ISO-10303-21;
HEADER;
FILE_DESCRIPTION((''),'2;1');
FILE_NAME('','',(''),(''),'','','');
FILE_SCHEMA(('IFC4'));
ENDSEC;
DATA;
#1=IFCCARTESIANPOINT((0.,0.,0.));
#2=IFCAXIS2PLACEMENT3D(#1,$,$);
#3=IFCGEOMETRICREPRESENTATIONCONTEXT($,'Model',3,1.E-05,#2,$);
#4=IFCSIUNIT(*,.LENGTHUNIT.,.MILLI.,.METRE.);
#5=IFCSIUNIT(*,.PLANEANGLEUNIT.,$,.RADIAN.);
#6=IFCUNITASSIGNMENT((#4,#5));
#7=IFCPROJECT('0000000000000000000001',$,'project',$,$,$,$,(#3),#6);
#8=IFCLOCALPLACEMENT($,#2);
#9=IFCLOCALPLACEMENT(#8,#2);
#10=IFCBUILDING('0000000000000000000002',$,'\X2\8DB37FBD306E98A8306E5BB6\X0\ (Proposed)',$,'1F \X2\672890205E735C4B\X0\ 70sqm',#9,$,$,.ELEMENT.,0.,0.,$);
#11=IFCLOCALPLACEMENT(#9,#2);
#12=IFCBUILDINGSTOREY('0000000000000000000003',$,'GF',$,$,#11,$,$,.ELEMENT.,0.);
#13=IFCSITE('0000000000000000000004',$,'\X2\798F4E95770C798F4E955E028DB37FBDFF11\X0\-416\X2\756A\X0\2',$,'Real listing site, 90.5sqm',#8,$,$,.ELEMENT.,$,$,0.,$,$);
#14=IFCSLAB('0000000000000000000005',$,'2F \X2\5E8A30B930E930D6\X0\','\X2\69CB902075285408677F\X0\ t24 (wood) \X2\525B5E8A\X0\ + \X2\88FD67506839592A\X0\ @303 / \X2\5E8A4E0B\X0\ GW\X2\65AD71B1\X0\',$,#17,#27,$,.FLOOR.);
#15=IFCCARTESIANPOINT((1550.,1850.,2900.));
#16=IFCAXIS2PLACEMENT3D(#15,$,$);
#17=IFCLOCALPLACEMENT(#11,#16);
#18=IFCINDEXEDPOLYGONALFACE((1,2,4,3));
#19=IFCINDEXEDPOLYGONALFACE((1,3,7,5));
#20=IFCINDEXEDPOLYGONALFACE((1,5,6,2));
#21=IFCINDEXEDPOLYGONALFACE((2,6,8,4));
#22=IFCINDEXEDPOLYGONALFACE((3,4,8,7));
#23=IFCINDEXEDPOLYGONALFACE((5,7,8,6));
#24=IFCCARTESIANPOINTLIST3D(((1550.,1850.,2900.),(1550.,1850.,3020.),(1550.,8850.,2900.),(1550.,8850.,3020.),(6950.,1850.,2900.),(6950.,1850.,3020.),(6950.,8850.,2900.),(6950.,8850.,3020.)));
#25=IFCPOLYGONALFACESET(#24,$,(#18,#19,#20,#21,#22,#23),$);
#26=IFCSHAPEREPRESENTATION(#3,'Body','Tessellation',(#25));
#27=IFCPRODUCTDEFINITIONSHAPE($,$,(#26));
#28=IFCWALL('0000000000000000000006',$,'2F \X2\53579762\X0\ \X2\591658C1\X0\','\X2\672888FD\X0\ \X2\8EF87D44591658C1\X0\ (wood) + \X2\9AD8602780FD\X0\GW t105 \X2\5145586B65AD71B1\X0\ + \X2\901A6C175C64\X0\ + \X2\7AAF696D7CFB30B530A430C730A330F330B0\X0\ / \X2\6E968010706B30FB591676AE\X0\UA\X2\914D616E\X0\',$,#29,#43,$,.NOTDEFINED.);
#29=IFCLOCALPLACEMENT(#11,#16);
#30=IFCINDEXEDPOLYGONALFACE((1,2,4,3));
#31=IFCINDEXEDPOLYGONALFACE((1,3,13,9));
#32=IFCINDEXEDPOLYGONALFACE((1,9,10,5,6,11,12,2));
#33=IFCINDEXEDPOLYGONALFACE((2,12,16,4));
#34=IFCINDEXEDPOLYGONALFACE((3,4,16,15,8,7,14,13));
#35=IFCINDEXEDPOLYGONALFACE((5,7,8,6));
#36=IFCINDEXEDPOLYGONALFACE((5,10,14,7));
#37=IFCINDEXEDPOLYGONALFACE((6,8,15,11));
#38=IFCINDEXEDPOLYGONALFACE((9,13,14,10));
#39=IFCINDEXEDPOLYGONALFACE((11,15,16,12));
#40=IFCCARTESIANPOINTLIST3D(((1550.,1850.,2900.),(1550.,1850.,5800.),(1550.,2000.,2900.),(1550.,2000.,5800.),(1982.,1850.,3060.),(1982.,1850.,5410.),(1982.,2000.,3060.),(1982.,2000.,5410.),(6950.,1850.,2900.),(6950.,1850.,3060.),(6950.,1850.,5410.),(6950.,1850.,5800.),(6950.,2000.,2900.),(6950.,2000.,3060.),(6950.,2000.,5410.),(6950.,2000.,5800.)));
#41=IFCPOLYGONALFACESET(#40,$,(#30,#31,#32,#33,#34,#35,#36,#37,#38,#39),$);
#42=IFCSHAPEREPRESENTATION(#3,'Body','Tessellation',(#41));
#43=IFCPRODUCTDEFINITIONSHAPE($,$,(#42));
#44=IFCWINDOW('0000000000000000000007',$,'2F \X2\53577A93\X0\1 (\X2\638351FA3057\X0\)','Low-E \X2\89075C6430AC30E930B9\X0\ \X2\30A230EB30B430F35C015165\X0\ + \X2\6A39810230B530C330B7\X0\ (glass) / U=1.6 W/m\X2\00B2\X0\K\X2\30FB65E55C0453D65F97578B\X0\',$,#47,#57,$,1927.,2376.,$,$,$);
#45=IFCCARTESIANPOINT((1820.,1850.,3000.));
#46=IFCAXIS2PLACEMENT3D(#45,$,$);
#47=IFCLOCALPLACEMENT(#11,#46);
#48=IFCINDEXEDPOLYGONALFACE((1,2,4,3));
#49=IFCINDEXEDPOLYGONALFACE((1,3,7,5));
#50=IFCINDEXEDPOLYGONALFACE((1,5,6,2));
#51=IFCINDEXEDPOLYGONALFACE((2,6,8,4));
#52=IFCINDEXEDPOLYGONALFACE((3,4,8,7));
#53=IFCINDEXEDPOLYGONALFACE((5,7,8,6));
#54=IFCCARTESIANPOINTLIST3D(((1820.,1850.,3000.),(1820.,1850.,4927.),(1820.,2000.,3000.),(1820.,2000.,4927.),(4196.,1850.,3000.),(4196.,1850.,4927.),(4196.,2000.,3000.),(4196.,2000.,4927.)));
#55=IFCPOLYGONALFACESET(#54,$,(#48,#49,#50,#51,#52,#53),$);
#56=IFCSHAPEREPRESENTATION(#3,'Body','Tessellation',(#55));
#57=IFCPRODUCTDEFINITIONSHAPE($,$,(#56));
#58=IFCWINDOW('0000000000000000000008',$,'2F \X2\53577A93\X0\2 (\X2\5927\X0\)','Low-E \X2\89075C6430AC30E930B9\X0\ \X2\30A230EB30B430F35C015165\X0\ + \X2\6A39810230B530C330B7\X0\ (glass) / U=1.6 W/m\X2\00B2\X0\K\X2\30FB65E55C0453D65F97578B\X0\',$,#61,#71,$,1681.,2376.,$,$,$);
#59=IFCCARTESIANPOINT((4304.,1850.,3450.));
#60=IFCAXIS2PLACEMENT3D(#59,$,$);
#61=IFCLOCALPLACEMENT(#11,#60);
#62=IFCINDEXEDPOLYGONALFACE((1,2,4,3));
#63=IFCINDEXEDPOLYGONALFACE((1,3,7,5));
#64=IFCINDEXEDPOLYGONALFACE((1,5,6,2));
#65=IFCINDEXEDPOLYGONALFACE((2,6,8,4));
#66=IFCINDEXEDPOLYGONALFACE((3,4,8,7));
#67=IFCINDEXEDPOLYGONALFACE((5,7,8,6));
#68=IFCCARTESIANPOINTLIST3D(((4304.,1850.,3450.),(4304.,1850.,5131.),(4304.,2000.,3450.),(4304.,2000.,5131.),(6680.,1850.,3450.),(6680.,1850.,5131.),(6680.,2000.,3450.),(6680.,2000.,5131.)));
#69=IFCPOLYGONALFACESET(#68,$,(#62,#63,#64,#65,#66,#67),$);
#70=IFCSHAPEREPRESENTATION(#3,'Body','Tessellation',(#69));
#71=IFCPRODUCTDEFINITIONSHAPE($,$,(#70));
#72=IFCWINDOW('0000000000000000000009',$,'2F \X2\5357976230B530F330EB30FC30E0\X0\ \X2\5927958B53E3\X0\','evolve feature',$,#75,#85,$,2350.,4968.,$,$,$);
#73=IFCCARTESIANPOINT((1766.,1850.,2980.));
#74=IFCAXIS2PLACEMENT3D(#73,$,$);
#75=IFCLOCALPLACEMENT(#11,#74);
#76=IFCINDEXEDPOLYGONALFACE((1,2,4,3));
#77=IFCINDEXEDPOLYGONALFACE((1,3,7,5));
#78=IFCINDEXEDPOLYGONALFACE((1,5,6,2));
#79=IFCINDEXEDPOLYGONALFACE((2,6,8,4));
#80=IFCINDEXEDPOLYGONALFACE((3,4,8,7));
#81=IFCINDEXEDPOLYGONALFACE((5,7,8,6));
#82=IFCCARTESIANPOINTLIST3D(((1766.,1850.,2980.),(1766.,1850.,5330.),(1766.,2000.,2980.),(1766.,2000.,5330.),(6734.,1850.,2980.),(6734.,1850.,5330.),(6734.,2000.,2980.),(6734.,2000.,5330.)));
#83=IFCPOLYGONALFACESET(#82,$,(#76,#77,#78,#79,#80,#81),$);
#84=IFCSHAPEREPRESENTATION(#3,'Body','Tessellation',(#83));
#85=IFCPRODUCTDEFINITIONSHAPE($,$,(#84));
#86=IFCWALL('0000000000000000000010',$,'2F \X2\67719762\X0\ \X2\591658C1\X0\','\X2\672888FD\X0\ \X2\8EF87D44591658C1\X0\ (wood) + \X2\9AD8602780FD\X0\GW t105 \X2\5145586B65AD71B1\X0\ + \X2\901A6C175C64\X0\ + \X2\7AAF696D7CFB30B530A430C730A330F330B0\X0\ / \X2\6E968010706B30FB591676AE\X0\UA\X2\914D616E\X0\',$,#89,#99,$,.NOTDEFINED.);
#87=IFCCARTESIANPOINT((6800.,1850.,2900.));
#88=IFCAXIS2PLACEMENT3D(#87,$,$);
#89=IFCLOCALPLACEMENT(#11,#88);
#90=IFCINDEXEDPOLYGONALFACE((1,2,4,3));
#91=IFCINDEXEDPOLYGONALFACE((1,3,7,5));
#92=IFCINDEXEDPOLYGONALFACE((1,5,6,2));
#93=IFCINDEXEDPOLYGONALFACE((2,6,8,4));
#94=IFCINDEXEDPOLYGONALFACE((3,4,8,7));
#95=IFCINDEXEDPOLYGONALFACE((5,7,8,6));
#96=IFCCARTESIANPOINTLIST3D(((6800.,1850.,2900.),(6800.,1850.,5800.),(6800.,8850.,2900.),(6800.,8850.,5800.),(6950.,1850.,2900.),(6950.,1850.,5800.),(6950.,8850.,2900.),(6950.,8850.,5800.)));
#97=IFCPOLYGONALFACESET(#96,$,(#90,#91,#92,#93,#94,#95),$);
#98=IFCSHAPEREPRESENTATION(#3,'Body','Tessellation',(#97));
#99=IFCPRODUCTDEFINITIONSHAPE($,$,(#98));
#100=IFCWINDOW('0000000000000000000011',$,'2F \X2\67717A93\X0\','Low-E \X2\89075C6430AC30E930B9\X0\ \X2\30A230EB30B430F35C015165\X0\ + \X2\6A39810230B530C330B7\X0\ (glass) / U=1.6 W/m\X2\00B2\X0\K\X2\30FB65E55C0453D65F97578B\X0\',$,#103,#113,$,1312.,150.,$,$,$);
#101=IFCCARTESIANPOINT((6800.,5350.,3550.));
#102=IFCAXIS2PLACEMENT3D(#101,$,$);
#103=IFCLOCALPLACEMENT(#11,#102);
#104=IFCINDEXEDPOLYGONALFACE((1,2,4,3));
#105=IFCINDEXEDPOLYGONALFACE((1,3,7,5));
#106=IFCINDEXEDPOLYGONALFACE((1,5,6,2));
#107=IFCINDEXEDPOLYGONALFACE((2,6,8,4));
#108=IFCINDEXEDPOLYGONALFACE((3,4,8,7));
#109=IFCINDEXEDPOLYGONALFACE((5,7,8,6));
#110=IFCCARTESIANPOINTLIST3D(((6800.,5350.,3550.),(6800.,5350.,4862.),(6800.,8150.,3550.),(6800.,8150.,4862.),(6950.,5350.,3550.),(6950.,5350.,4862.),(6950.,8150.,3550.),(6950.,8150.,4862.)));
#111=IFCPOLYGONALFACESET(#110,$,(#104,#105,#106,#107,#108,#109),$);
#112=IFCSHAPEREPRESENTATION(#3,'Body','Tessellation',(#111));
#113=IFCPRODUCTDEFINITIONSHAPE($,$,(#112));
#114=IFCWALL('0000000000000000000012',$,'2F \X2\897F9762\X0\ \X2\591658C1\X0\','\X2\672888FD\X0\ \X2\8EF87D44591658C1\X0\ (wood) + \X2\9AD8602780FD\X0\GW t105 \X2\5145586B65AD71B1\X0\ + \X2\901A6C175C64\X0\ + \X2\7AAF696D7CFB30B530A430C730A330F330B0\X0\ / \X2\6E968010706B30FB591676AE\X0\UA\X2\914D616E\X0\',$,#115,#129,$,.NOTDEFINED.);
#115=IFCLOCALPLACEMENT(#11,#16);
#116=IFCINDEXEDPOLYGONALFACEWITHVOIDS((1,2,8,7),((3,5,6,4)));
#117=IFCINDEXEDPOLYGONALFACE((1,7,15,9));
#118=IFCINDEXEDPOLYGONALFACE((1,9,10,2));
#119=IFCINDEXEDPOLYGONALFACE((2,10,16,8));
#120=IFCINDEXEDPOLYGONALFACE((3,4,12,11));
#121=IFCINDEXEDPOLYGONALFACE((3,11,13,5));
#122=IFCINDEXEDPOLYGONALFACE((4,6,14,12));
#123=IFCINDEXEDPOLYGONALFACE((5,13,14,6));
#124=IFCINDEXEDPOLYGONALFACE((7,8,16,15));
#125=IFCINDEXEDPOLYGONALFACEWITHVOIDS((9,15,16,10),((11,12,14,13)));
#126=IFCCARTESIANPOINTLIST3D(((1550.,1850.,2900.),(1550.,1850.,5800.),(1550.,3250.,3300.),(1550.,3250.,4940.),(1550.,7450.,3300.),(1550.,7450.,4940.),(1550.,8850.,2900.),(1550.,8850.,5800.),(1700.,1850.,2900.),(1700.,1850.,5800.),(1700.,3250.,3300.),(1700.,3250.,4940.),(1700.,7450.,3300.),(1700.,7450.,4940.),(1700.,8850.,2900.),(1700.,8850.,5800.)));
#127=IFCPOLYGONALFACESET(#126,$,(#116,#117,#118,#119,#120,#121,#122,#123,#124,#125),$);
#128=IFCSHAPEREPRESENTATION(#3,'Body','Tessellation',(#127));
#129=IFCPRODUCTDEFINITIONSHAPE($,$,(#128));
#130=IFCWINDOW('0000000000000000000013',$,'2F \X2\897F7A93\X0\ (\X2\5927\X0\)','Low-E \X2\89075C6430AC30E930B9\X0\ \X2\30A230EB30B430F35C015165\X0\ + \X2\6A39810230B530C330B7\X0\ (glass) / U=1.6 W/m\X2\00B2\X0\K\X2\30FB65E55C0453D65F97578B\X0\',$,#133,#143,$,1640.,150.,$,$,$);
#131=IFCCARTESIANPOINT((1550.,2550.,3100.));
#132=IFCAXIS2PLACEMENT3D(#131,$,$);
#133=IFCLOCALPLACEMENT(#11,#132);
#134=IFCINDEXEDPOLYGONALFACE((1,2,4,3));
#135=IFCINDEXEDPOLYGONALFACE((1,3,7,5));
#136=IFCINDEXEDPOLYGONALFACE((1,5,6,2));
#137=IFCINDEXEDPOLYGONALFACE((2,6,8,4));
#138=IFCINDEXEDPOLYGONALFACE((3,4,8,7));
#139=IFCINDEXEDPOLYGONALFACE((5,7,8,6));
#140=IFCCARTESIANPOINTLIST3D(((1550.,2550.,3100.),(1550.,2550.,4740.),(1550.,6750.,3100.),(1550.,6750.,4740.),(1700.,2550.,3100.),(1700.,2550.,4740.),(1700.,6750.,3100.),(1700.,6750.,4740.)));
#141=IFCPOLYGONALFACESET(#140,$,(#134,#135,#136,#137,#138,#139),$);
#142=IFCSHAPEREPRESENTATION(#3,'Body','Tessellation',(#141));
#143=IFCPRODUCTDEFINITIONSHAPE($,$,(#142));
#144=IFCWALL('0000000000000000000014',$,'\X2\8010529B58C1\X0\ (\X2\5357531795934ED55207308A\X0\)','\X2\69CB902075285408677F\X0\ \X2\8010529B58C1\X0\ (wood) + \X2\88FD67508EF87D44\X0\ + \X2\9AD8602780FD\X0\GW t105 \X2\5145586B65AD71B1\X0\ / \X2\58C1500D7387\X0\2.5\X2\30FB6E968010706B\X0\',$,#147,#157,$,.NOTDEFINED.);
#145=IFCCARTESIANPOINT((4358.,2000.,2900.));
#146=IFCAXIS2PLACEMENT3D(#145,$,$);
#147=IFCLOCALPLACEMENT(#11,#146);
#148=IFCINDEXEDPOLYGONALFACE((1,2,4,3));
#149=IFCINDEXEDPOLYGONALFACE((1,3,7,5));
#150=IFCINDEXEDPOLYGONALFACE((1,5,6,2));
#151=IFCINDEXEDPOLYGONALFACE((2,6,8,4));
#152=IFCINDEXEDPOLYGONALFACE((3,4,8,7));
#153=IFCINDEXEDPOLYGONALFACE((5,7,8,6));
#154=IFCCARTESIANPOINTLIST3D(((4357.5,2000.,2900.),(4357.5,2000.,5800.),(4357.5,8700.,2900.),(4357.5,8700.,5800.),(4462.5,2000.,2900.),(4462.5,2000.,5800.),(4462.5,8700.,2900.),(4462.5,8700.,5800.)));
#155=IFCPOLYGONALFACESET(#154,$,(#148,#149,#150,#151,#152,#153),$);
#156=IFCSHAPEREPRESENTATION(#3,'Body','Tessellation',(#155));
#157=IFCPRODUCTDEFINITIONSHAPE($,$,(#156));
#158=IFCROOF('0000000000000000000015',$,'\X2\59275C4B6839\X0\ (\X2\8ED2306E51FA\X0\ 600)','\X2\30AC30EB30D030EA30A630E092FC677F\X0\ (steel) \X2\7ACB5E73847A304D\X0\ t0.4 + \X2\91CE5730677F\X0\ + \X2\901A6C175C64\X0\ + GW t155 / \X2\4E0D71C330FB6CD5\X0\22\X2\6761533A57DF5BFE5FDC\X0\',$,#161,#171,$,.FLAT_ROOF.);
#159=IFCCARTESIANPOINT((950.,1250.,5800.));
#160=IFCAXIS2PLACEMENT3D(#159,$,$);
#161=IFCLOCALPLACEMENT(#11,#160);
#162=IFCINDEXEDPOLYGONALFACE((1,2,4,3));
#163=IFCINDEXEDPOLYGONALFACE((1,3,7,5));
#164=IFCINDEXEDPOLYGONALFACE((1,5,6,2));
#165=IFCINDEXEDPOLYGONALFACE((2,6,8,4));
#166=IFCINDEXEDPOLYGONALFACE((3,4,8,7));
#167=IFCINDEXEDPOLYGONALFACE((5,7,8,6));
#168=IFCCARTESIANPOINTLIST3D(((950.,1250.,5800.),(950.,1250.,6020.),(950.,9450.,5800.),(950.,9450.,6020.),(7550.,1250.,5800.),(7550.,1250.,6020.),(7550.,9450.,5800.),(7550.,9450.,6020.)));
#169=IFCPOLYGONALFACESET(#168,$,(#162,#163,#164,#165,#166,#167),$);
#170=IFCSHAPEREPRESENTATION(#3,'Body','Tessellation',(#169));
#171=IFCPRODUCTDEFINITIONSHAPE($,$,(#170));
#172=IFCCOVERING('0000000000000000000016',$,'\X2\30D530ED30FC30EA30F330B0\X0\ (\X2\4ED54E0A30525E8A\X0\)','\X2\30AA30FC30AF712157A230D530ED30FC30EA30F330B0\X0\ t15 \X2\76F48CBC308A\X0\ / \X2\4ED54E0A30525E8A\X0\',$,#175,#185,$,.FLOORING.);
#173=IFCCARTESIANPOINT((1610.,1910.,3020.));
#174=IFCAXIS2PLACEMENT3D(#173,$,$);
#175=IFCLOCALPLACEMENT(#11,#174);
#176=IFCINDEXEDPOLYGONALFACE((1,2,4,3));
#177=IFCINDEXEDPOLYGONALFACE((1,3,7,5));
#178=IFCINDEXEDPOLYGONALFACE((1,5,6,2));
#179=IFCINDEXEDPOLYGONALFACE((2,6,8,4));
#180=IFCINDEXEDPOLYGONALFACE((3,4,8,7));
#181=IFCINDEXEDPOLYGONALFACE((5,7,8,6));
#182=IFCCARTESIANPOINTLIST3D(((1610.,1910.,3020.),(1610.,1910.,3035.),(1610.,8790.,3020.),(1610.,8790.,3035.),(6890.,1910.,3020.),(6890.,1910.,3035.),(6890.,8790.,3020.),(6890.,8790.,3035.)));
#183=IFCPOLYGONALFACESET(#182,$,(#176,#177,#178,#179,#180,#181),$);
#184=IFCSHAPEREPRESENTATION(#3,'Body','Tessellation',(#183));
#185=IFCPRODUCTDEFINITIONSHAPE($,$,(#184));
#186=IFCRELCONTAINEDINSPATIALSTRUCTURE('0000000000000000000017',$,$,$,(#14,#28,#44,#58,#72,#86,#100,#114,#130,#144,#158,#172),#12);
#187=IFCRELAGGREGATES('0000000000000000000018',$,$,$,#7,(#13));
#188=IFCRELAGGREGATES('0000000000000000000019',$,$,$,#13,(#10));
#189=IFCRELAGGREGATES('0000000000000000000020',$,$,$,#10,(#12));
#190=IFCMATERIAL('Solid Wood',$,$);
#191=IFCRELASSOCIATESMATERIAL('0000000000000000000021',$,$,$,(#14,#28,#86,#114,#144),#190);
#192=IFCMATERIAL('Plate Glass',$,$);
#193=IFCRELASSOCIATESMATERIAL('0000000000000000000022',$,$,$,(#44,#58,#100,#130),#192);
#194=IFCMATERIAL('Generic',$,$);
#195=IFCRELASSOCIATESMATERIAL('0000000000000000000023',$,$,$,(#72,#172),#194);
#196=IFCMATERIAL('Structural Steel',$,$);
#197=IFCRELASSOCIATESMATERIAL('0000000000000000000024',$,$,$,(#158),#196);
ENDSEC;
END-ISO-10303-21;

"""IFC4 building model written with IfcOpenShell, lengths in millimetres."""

from ifc_helpers import new_model, si_unit, frame, frame_2d, origin, place, context, project, spatial, rectangle, extrude, material, element, fill, save


model = new_model("IFC4")

# Units and contexts
model_context = context("Model", 3, precision=1e-05, world=origin())
ifc_project = project(units=[si_unit("LENGTHUNIT", "METRE", prefix="MILLI"), si_unit("PLANEANGLEUNIT", "RADIAN")], contexts=[model_context])

# Site, building, storey
site_placement = place(None, origin())
site = spatial("IfcSite", under=ifc_project, at=site_placement, Name="福井県福井市足羽１-416番2", ObjectType="Real listing site, 90.5sqm", CompositionType="ELEMENT", RefElevation=0.0)
building_placement = place(site_placement, origin())
building = spatial("IfcBuilding", under=site, at=building_placement, Name="足羽の風の家 (Proposed)", ObjectType="1F 木造平屋 70sqm", CompositionType="ELEMENT", ElevationOfRefHeight=0.0, ElevationOfTerrain=0.0)
storey_placement = place(building_placement, origin())
storey = spatial("IfcBuildingStorey", under=building, at=storey_placement, Name="GF", CompositionType="ELEMENT", Elevation=0.0)

# Slab
ifc_material_1 = material(Name="Solid Wood")
slab_placement = place(storey_placement, frame((1550.0, 1850.0, 2900.0)))
element("IfcSlab", 1, at=slab_placement, inside=storey, material=ifc_material_1, Name="2F 床スラブ", Description="構造用合板 t24 (wood) 剛床 + 製材根太 @303 / 床下 GW断熱", PredefinedType="FLOOR", context=model_context, shape_type="SweptSolid", body=[
    extrude(rectangle(XDim=5400.0, YDim=7000.0, at=frame_2d((2700.0, 3500.0))), frame((1550.0, 1850.0, 2900.0)), (0.0, 0.0, 1.0), 120.0),
])

# Wall, openings, windows
wall_1_placement = place(storey_placement, frame((1550.0, 1850.0, 2900.0)))
wall_1 = element("IfcWall", 2, at=wall_1_placement, inside=storey, material=ifc_material_1, Name="2F 南面 外壁", Description="木製 軸組外壁 (wood) + 高性能GW t105 充填断熱 + 通気層 + 窯業系サイディング / 準耐火・外皮UA配慮", PredefinedType="NOTDEFINED", context=model_context, shape_type="SweptSolid", body=[
    extrude(rectangle(XDim=5400.0, YDim=150.0, at=frame_2d((2700.0, 75.0))), frame((1550.0, 1850.0, 2900.0)), (0.0, 0.0, 1.0), 2900.0),
])
opening_1_placement = place(storey_placement, frame((1820.0, 1850.0, 3000.0)))
opening_1 = element("IfcOpeningElement", 3, at=opening_1_placement, cuts=wall_1, PredefinedType="NOTDEFINED", context=model_context, shape_type="SweptSolid", body=[
    extrude(rectangle(XDim=2376.0, YDim=150.0, at=frame_2d((1188.0, 75.0))), frame((1820.0, 1850.0, 3000.0)), (0.0, 0.0, 1.0), 1927.0),
])
opening_2_placement = place(storey_placement, frame((4304.0, 1850.0, 3450.0)))
opening_2 = element("IfcOpeningElement", 4, at=opening_2_placement, cuts=wall_1, PredefinedType="NOTDEFINED", context=model_context, shape_type="SweptSolid", body=[
    extrude(rectangle(XDim=2376.0, YDim=150.0, at=frame_2d((1188.0, 75.0))), frame((4304.0, 1850.0, 3450.0)), (0.0, 0.0, 1.0), 1681.0),
])
opening_3_placement = place(storey_placement, frame((1766.0, 1850.0, 2980.0)))
opening_3 = element("IfcOpeningElement", 5, at=opening_3_placement, cuts=wall_1, PredefinedType="NOTDEFINED", context=model_context, shape_type="SweptSolid", body=[
    extrude(rectangle(XDim=4968.0, YDim=150.0, at=frame_2d((2484.0, 75.0))), frame((1766.0, 1850.0, 2980.0)), (0.0, 0.0, 1.0), 2350.0),
])
ifc_material_2 = material(Name="Plate Glass")
window_1_placement = place(storey_placement, frame((1820.0, 1850.0, 3000.0)))
window_1 = element("IfcWindow", 6, at=window_1_placement, inside=storey, material=ifc_material_2, Name="2F 南窓1 (掃出し)", Description="Low-E 複層ガラス アルゴン封入 + 樹脂サッシ (glass) / U=1.6 W/m²K・日射取得型", OverallHeight=1927.0, OverallWidth=2376.0, context=model_context, shape_type="SweptSolid", body=[
    extrude(rectangle(XDim=2376.0, YDim=150.0, at=frame_2d((1188.0, 75.0))), frame((1820.0, 1850.0, 3000.0)), (0.0, 0.0, 1.0), 1927.0),
])
fill(opening_1, window_1)
window_2_placement = place(storey_placement, frame((4304.0, 1850.0, 3450.0)))
window_2 = element("IfcWindow", 7, at=window_2_placement, inside=storey, material=ifc_material_2, Name="2F 南窓2 (大)", Description="Low-E 複層ガラス アルゴン封入 + 樹脂サッシ (glass) / U=1.6 W/m²K・日射取得型", OverallHeight=1681.0, OverallWidth=2376.0, context=model_context, shape_type="SweptSolid", body=[
    extrude(rectangle(XDim=2376.0, YDim=150.0, at=frame_2d((1188.0, 75.0))), frame((4304.0, 1850.0, 3450.0)), (0.0, 0.0, 1.0), 1681.0),
])
fill(opening_2, window_2)
ifc_material_3 = material(Name="Generic")
window_3_placement = place(storey_placement, frame((1766.0, 1850.0, 2980.0)))
window_3 = element("IfcWindow", 8, at=window_3_placement, inside=storey, material=ifc_material_3, Name="2F 南面サンルーム 大開口", Description="evolve feature", OverallHeight=2350.0, OverallWidth=4968.0, context=model_context, shape_type="SweptSolid", body=[
    extrude(rectangle(XDim=4968.0, YDim=150.0, at=frame_2d((2484.0, 75.0))), frame((1766.0, 1850.0, 2980.0)), (0.0, 0.0, 1.0), 2350.0),
])
fill(opening_3, window_3)

# Walls, openings, windows
wall_2_placement = place(storey_placement, frame((6800.0, 1850.0, 2900.0)))
wall_2 = element("IfcWall", 9, at=wall_2_placement, inside=storey, material=ifc_material_1, Name="2F 東面 外壁", Description="木製 軸組外壁 (wood) + 高性能GW t105 充填断熱 + 通気層 + 窯業系サイディング / 準耐火・外皮UA配慮", PredefinedType="NOTDEFINED", context=model_context, shape_type="SweptSolid", body=[
    extrude(rectangle(XDim=150.0, YDim=7000.0, at=frame_2d((75.0, 3500.0))), frame((6800.0, 1850.0, 2900.0)), (0.0, 0.0, 1.0), 2900.0),
])
opening_4_placement = place(storey_placement, frame((6800.0, 5350.0, 3550.0)))
opening_4 = element("IfcOpeningElement", 10, at=opening_4_placement, cuts=wall_2, PredefinedType="NOTDEFINED", context=model_context, shape_type="SweptSolid", body=[
    extrude(rectangle(XDim=150.0, YDim=2800.0, at=frame_2d((75.0, 1400.0))), frame((6800.0, 5350.0, 3550.0)), (0.0, 0.0, 1.0), 1312.0),
])
window_4_placement = place(storey_placement, frame((6800.0, 5350.0, 3550.0)))
window_4 = element("IfcWindow", 11, at=window_4_placement, inside=storey, material=ifc_material_2, Name="2F 東窓", Description="Low-E 複層ガラス アルゴン封入 + 樹脂サッシ (glass) / U=1.6 W/m²K・日射取得型", OverallHeight=1312.0, OverallWidth=150.0, context=model_context, shape_type="SweptSolid", body=[
    extrude(rectangle(XDim=150.0, YDim=2800.0, at=frame_2d((75.0, 1400.0))), frame((6800.0, 5350.0, 3550.0)), (0.0, 0.0, 1.0), 1312.0),
])
fill(opening_4, window_4)
wall_3_placement = place(storey_placement, frame((1550.0, 1850.0, 2900.0)))
wall_3 = element("IfcWall", 12, at=wall_3_placement, inside=storey, material=ifc_material_1, Name="2F 西面 外壁", Description="木製 軸組外壁 (wood) + 高性能GW t105 充填断熱 + 通気層 + 窯業系サイディング / 準耐火・外皮UA配慮", PredefinedType="NOTDEFINED", context=model_context, shape_type="SweptSolid", body=[
    extrude(rectangle(XDim=150.0, YDim=7000.0, at=frame_2d((75.0, 3500.0))), frame((1550.0, 1850.0, 2900.0)), (0.0, 0.0, 1.0), 2900.0),
])
opening_5_placement = place(storey_placement, frame((1550.0, 2550.0, 3100.0)))
opening_5 = element("IfcOpeningElement", 13, at=opening_5_placement, cuts=wall_3, PredefinedType="NOTDEFINED", context=model_context, shape_type="SweptSolid", body=[
    extrude(rectangle(XDim=150.0, YDim=4200.0, at=frame_2d((75.0, 2100.0))), frame((1550.0, 2550.0, 3100.0)), (0.0, 0.0, 1.0), 1640.0),
])
window_5_placement = place(storey_placement, frame((1550.0, 2550.0, 3100.0)))
window_5 = element("IfcWindow", 14, at=window_5_placement, inside=storey, material=ifc_material_2, Name="2F 西窓 (大)", Description="Low-E 複層ガラス アルゴン封入 + 樹脂サッシ (glass) / U=1.6 W/m²K・日射取得型", OverallHeight=1640.0, OverallWidth=150.0, context=model_context, shape_type="SweptSolid", body=[
    extrude(rectangle(XDim=150.0, YDim=4200.0, at=frame_2d((75.0, 2100.0))), frame((1550.0, 2550.0, 3100.0)), (0.0, 0.0, 1.0), 1640.0),
])
fill(opening_5, window_5)

# Wall
wall_4_placement = place(storey_placement, frame((4358.0, 2000.0, 2900.0)))
element("IfcWall", 15, at=wall_4_placement, inside=storey, material=ifc_material_1, Name="耐力壁 (南北間仕切り)", Description="構造用合板 耐力壁 (wood) + 製材軸組 + 高性能GW t105 充填断熱 / 壁倍率2.5・準耐火", PredefinedType="NOTDEFINED", context=model_context, shape_type="SweptSolid", body=[
    extrude(rectangle(XDim=105.0, YDim=6700.0, at=frame_2d((52.0, 3350.0))), frame((4358.0, 2000.0, 2900.0)), (0.0, 0.0, 1.0), 2900.0),
])

# Roof
ifc_material_4 = material(Name="Structural Steel")
roof_placement = place(storey_placement, frame((950.0, 1250.0, 5800.0)))
element("IfcRoof", 16, at=roof_placement, inside=storey, material=ifc_material_4, Name="大屋根 (軒の出 600)", Description="ガルバリウム鋼板 (steel) 立平葺き t0.4 + 野地板 + 通気層 + GW t155 / 不燃・法22条区域対応", PredefinedType="FLAT_ROOF", context=model_context, shape_type="SweptSolid", body=[
    extrude(rectangle(XDim=6600.0, YDim=8200.0, at=frame_2d((3300.0, 4100.0))), frame((950.0, 1250.0, 5800.0)), (0.0, 0.0, 1.0), 220.0),
])

# Covering
covering_placement = place(storey_placement, frame((1610.0, 1910.0, 3020.0)))
element("IfcCovering", 17, at=covering_placement, inside=storey, material=ifc_material_3, Name="フローリング (仕上げ床)", Description="オーク無垢フローリング t15 直貼り / 仕上げ床", PredefinedType="FLOORING", context=model_context, shape_type="SweptSolid", body=[
    extrude(rectangle(XDim=5280.0, YDim=6880.0, at=frame_2d((2640.0, 3440.0))), frame((1610.0, 1910.0, 3020.0)), (0.0, 0.0, 1.0), 15.0),
])

save(model, "model.ifc")
